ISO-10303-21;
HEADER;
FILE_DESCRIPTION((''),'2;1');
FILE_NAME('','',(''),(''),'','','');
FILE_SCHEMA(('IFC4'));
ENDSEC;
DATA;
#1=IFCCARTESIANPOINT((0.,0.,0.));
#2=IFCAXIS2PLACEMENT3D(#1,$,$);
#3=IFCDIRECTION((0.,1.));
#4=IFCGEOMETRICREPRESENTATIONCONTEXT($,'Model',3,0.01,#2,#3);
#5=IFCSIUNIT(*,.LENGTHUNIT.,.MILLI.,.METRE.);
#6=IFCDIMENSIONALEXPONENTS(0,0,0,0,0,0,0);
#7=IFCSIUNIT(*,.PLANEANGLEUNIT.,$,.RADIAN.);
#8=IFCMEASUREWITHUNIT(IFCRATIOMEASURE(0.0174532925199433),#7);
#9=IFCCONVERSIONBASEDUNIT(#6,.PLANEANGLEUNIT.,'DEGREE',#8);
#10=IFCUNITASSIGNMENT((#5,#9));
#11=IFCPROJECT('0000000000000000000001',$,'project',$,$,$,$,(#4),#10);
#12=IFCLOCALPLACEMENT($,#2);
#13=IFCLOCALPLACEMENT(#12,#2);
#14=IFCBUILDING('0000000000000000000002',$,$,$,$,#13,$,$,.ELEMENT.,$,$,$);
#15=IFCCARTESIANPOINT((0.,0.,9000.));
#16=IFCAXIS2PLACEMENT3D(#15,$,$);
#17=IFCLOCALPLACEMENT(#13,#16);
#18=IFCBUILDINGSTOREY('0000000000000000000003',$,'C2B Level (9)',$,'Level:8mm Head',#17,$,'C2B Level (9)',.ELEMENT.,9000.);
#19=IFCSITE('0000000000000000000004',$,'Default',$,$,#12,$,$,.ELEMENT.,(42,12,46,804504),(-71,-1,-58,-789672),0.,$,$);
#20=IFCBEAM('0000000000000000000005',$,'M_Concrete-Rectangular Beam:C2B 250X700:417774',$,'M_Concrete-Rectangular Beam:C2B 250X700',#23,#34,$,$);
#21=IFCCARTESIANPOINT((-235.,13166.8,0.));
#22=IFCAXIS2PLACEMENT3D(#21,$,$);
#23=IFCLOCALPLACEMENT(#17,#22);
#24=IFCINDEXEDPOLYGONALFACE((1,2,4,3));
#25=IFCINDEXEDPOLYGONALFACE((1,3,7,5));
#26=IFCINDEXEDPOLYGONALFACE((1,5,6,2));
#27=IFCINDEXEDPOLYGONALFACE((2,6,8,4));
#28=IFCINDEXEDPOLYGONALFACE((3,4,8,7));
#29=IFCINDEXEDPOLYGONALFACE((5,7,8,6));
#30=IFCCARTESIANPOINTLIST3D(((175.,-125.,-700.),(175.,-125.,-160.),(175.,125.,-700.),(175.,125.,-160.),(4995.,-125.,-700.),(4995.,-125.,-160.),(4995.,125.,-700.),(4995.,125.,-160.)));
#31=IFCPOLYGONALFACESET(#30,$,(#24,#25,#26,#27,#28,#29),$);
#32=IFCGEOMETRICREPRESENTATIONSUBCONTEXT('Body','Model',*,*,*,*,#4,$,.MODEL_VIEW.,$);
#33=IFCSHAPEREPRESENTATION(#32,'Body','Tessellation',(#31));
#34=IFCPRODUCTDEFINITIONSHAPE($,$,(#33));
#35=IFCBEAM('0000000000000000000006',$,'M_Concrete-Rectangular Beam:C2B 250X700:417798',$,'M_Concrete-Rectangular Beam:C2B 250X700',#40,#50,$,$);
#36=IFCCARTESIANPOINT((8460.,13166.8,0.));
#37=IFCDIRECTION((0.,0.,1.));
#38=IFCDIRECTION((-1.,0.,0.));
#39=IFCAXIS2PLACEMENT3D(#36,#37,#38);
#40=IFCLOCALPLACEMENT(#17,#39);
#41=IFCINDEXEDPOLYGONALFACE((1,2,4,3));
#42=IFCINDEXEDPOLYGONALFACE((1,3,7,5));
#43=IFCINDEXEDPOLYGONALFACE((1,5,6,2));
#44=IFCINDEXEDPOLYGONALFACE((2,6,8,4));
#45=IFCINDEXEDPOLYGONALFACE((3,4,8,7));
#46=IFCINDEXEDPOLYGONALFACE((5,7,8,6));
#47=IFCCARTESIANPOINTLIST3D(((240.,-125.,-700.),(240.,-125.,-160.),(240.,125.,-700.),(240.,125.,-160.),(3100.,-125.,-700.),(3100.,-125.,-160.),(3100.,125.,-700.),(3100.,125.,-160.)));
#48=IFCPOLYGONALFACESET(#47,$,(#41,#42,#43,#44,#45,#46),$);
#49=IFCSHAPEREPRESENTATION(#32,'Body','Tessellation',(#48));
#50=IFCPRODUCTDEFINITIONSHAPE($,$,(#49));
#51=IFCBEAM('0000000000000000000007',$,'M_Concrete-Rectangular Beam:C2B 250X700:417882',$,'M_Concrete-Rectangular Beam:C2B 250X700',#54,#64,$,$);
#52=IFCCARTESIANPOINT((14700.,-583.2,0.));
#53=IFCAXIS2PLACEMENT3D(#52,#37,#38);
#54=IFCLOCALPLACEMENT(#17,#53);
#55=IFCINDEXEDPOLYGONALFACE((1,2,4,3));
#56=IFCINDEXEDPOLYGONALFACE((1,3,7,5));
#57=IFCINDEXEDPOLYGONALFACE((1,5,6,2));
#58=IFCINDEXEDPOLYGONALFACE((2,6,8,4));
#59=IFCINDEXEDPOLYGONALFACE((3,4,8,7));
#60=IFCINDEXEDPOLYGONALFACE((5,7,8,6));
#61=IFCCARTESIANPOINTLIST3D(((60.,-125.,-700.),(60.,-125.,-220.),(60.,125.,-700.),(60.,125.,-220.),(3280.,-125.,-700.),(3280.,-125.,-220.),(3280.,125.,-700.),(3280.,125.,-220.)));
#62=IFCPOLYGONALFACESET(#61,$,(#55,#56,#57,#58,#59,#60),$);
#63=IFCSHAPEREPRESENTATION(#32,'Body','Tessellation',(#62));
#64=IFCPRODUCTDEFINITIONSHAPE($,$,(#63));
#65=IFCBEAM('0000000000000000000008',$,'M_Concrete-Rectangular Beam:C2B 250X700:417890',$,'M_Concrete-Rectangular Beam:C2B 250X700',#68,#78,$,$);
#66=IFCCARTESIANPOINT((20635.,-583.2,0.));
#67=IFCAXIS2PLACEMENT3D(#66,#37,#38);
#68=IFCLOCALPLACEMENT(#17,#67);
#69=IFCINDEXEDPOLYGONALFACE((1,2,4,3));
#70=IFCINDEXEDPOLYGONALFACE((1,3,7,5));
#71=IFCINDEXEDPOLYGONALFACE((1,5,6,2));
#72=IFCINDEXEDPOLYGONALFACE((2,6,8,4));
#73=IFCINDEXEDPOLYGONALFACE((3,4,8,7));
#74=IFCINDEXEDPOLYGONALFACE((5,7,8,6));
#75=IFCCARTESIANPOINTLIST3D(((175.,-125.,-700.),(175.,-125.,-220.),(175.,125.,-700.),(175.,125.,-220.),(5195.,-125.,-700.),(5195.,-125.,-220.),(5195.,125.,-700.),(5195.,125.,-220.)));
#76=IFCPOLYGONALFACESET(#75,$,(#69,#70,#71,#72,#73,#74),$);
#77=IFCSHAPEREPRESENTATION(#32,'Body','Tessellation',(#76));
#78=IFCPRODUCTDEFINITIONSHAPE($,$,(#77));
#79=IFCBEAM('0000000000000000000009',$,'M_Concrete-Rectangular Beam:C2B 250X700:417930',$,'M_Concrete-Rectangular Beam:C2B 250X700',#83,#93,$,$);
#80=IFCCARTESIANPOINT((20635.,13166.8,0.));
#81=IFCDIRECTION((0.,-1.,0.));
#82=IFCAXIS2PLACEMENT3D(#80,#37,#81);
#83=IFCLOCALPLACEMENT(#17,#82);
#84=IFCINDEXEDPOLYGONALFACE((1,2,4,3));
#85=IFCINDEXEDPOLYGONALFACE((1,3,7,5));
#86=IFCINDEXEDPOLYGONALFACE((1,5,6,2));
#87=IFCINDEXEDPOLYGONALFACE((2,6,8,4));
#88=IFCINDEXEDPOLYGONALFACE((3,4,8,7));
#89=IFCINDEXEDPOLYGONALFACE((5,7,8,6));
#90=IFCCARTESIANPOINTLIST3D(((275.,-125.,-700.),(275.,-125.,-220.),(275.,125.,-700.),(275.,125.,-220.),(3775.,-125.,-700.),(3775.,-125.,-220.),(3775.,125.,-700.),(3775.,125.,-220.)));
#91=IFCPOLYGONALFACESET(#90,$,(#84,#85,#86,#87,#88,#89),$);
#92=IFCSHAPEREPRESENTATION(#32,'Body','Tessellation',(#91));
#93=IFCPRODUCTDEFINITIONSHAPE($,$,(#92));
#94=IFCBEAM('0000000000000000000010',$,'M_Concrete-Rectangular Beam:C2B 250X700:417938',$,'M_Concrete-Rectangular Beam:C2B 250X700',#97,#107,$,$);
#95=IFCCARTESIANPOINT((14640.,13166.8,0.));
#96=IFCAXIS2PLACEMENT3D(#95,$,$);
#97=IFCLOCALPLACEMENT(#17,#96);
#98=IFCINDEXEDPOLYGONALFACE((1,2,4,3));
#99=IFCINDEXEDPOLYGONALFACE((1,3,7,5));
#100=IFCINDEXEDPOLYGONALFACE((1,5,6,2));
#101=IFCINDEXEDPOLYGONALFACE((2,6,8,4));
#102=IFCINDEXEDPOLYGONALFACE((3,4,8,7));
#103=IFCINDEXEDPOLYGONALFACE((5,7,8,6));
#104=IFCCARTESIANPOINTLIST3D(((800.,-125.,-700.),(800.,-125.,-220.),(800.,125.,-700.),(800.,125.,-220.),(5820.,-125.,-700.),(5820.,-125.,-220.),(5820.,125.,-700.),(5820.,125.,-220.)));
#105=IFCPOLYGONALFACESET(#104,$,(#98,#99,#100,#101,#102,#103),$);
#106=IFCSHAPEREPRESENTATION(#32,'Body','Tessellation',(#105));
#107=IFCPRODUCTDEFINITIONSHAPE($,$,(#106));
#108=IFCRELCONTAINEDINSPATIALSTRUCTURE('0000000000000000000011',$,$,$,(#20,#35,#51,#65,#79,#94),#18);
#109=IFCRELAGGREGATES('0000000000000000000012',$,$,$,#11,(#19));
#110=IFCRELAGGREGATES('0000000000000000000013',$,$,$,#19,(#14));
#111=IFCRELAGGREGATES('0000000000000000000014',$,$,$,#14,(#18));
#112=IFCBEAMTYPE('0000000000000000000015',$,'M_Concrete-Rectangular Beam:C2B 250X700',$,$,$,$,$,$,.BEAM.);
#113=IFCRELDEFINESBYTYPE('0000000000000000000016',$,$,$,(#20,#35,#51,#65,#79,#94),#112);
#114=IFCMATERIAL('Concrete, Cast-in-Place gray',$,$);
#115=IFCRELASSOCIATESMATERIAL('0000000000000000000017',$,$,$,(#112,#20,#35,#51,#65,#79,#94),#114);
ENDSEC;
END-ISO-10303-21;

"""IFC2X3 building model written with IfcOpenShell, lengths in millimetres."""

from ifc_helpers import new_model, entity, si_unit, converted_unit, direction, frame, frame_2d, origin, place, context, subcontext, project, spatial, rectangle, extrude, material, type_object, element, save


model = new_model("IFC2X3")

# Units and contexts
model_context = context("Model", 3, precision=0.01, world=origin(), true_north=direction((0.0, 1.0)))
body_context = subcontext(model_context, "Body", "Model", "MODEL_VIEW")
ifc_project = project(units=[si_unit("LENGTHUNIT", "METRE", prefix="MILLI"), converted_unit("PLANEANGLEUNIT", "DEGREE", entity("IfcRatioMeasure", 0.0174532925199433), si_unit("PLANEANGLEUNIT", "RADIAN"), dimensions=[0, 0, 0, 0, 0, 0, 0])], contexts=[model_context])

# Site, building, storey
site_placement = place(None, origin())
site = spatial("IfcSite", under=ifc_project, at=site_placement, Name="Default", CompositionType="ELEMENT", RefLatitude=(42, 12, 46, 804504), RefLongitude=(-71, -1, -58, -789672), RefElevation=0.0)
building_placement = place(site_placement, origin())
building = spatial("IfcBuilding", under=site, at=building_placement, CompositionType="ELEMENT")
storey_placement = place(building_placement, frame((0.0, 0.0, 9000.0)))
storey = spatial("IfcBuildingStorey", under=building, at=storey_placement, Name="C2B Level (9)", ObjectType="Level:8mm Head", LongName="C2B Level (9)", CompositionType="ELEMENT", Elevation=9000.0)

# Beams
ifc_material_1 = material(Name="Concrete, Cast-in-Place gray")
beam_type_1 = type_object("IfcBeamType", Name="M_Concrete-Rectangular Beam:C2B 250X700", PredefinedType="BEAM", material=ifc_material_1)
beam_1_placement = place(storey_placement, frame((-235.0, 13166.8, 0.0)))
element("IfcBeam", 1, at=beam_1_placement, inside=storey, type_object=beam_type_1, material=ifc_material_1, Name="M_Concrete-Rectangular Beam:C2B 250X700:417774", ObjectType="M_Concrete-Rectangular Beam:C2B 250X700", context=body_context, shape_type="SweptSolid", body=[
    extrude(rectangle(XDim=540.0, YDim=250.0, at=frame_2d((0.0, 0.0), x_axis=(1.0, 0.0))), frame((175.0, 0.0, -430.0), z_axis=(1.0, 0.0, 0.0), x_axis=(0.0, 0.0, -1.0)), (0.0, 0.0, 1.0), 4820.0),
])
beam_2_placement = place(storey_placement, frame((8460.0, 13166.8, 0.0), z_axis=(0.0, 0.0, 1.0), x_axis=(-1.0, 0.0, 0.0)))
element("IfcBeam", 2, at=beam_2_placement, inside=storey, type_object=beam_type_1, material=ifc_material_1, Name="M_Concrete-Rectangular Beam:C2B 250X700:417798", ObjectType="M_Concrete-Rectangular Beam:C2B 250X700", context=body_context, shape_type="SweptSolid", body=[
    extrude(rectangle(XDim=540.0, YDim=250.0, at=frame_2d((0.0, 0.0), x_axis=(1.0, 0.0))), frame((240.0, 0.0, -430.0), z_axis=(1.0, 0.0, 0.0), x_axis=(0.0, 0.0, -1.0)), (0.0, 0.0, 1.0), 2860.0),
])
beam_3_placement = place(storey_placement, frame((14700.0, -583.2, 0.0), z_axis=(0.0, 0.0, 1.0), x_axis=(-1.0, 0.0, 0.0)))
element("IfcBeam", 3, at=beam_3_placement, inside=storey, type_object=beam_type_1, material=ifc_material_1, Name="M_Concrete-Rectangular Beam:C2B 250X700:417882", ObjectType="M_Concrete-Rectangular Beam:C2B 250X700", context=body_context, shape_type="SweptSolid", body=[
    extrude(rectangle(XDim=480.0, YDim=250.0, at=frame_2d((0.0, 0.0), x_axis=(1.0, 0.0))), frame((60.0, 0.0, -460.0), z_axis=(1.0, 0.0, 0.0), x_axis=(0.0, 0.0, -1.0)), (0.0, 0.0, 1.0), 3220.0),
])
beam_4_placement = place(storey_placement, frame((20635.0, -583.2, 0.0), z_axis=(0.0, 0.0, 1.0), x_axis=(-1.0, 0.0, 0.0)))
element("IfcBeam", 4, at=beam_4_placement, inside=storey, type_object=beam_type_1, material=ifc_material_1, Name="M_Concrete-Rectangular Beam:C2B 250X700:417890", ObjectType="M_Concrete-Rectangular Beam:C2B 250X700", context=body_context, shape_type="SweptSolid", body=[
    extrude(rectangle(XDim=480.0, YDim=250.0, at=frame_2d((0.0, 0.0), x_axis=(1.0, 0.0))), frame((175.0, 0.0, -460.0), z_axis=(1.0, 0.0, 0.0), x_axis=(0.0, 0.0, -1.0)), (0.0, 0.0, 1.0), 5020.0),
])
beam_5_placement = place(storey_placement, frame((20635.0, 13166.8, 0.0), z_axis=(0.0, 0.0, 1.0), x_axis=(0.0, -1.0, 0.0)))
element("IfcBeam", 5, at=beam_5_placement, inside=storey, type_object=beam_type_1, material=ifc_material_1, Name="M_Concrete-Rectangular Beam:C2B 250X700:417930", ObjectType="M_Concrete-Rectangular Beam:C2B 250X700", context=body_context, shape_type="SweptSolid", body=[
    extrude(rectangle(XDim=480.0, YDim=250.0, at=frame_2d((0.0, 0.0), x_axis=(1.0, 0.0))), frame((275.0, 0.0, -460.0), z_axis=(1.0, 0.0, 0.0), x_axis=(0.0, 0.0, -1.0)), (0.0, 0.0, 1.0), 3500.0),
])
beam_6_placement = place(storey_placement, frame((14640.0, 13166.8, 0.0)))
element("IfcBeam", 6, at=beam_6_placement, inside=storey, type_object=beam_type_1, material=ifc_material_1, Name="M_Concrete-Rectangular Beam:C2B 250X700:417938", ObjectType="M_Concrete-Rectangular Beam:C2B 250X700", context=body_context, shape_type="SweptSolid", body=[
    extrude(rectangle(XDim=480.0, YDim=250.0, at=frame_2d((0.0, 0.0), x_axis=(1.0, 0.0))), frame((800.0, 0.0, -460.0), z_axis=(1.0, 0.0, 0.0), x_axis=(0.0, 0.0, -1.0)), (0.0, 0.0, 1.0), 5020.0),
])

save(model, "model.ifc")
